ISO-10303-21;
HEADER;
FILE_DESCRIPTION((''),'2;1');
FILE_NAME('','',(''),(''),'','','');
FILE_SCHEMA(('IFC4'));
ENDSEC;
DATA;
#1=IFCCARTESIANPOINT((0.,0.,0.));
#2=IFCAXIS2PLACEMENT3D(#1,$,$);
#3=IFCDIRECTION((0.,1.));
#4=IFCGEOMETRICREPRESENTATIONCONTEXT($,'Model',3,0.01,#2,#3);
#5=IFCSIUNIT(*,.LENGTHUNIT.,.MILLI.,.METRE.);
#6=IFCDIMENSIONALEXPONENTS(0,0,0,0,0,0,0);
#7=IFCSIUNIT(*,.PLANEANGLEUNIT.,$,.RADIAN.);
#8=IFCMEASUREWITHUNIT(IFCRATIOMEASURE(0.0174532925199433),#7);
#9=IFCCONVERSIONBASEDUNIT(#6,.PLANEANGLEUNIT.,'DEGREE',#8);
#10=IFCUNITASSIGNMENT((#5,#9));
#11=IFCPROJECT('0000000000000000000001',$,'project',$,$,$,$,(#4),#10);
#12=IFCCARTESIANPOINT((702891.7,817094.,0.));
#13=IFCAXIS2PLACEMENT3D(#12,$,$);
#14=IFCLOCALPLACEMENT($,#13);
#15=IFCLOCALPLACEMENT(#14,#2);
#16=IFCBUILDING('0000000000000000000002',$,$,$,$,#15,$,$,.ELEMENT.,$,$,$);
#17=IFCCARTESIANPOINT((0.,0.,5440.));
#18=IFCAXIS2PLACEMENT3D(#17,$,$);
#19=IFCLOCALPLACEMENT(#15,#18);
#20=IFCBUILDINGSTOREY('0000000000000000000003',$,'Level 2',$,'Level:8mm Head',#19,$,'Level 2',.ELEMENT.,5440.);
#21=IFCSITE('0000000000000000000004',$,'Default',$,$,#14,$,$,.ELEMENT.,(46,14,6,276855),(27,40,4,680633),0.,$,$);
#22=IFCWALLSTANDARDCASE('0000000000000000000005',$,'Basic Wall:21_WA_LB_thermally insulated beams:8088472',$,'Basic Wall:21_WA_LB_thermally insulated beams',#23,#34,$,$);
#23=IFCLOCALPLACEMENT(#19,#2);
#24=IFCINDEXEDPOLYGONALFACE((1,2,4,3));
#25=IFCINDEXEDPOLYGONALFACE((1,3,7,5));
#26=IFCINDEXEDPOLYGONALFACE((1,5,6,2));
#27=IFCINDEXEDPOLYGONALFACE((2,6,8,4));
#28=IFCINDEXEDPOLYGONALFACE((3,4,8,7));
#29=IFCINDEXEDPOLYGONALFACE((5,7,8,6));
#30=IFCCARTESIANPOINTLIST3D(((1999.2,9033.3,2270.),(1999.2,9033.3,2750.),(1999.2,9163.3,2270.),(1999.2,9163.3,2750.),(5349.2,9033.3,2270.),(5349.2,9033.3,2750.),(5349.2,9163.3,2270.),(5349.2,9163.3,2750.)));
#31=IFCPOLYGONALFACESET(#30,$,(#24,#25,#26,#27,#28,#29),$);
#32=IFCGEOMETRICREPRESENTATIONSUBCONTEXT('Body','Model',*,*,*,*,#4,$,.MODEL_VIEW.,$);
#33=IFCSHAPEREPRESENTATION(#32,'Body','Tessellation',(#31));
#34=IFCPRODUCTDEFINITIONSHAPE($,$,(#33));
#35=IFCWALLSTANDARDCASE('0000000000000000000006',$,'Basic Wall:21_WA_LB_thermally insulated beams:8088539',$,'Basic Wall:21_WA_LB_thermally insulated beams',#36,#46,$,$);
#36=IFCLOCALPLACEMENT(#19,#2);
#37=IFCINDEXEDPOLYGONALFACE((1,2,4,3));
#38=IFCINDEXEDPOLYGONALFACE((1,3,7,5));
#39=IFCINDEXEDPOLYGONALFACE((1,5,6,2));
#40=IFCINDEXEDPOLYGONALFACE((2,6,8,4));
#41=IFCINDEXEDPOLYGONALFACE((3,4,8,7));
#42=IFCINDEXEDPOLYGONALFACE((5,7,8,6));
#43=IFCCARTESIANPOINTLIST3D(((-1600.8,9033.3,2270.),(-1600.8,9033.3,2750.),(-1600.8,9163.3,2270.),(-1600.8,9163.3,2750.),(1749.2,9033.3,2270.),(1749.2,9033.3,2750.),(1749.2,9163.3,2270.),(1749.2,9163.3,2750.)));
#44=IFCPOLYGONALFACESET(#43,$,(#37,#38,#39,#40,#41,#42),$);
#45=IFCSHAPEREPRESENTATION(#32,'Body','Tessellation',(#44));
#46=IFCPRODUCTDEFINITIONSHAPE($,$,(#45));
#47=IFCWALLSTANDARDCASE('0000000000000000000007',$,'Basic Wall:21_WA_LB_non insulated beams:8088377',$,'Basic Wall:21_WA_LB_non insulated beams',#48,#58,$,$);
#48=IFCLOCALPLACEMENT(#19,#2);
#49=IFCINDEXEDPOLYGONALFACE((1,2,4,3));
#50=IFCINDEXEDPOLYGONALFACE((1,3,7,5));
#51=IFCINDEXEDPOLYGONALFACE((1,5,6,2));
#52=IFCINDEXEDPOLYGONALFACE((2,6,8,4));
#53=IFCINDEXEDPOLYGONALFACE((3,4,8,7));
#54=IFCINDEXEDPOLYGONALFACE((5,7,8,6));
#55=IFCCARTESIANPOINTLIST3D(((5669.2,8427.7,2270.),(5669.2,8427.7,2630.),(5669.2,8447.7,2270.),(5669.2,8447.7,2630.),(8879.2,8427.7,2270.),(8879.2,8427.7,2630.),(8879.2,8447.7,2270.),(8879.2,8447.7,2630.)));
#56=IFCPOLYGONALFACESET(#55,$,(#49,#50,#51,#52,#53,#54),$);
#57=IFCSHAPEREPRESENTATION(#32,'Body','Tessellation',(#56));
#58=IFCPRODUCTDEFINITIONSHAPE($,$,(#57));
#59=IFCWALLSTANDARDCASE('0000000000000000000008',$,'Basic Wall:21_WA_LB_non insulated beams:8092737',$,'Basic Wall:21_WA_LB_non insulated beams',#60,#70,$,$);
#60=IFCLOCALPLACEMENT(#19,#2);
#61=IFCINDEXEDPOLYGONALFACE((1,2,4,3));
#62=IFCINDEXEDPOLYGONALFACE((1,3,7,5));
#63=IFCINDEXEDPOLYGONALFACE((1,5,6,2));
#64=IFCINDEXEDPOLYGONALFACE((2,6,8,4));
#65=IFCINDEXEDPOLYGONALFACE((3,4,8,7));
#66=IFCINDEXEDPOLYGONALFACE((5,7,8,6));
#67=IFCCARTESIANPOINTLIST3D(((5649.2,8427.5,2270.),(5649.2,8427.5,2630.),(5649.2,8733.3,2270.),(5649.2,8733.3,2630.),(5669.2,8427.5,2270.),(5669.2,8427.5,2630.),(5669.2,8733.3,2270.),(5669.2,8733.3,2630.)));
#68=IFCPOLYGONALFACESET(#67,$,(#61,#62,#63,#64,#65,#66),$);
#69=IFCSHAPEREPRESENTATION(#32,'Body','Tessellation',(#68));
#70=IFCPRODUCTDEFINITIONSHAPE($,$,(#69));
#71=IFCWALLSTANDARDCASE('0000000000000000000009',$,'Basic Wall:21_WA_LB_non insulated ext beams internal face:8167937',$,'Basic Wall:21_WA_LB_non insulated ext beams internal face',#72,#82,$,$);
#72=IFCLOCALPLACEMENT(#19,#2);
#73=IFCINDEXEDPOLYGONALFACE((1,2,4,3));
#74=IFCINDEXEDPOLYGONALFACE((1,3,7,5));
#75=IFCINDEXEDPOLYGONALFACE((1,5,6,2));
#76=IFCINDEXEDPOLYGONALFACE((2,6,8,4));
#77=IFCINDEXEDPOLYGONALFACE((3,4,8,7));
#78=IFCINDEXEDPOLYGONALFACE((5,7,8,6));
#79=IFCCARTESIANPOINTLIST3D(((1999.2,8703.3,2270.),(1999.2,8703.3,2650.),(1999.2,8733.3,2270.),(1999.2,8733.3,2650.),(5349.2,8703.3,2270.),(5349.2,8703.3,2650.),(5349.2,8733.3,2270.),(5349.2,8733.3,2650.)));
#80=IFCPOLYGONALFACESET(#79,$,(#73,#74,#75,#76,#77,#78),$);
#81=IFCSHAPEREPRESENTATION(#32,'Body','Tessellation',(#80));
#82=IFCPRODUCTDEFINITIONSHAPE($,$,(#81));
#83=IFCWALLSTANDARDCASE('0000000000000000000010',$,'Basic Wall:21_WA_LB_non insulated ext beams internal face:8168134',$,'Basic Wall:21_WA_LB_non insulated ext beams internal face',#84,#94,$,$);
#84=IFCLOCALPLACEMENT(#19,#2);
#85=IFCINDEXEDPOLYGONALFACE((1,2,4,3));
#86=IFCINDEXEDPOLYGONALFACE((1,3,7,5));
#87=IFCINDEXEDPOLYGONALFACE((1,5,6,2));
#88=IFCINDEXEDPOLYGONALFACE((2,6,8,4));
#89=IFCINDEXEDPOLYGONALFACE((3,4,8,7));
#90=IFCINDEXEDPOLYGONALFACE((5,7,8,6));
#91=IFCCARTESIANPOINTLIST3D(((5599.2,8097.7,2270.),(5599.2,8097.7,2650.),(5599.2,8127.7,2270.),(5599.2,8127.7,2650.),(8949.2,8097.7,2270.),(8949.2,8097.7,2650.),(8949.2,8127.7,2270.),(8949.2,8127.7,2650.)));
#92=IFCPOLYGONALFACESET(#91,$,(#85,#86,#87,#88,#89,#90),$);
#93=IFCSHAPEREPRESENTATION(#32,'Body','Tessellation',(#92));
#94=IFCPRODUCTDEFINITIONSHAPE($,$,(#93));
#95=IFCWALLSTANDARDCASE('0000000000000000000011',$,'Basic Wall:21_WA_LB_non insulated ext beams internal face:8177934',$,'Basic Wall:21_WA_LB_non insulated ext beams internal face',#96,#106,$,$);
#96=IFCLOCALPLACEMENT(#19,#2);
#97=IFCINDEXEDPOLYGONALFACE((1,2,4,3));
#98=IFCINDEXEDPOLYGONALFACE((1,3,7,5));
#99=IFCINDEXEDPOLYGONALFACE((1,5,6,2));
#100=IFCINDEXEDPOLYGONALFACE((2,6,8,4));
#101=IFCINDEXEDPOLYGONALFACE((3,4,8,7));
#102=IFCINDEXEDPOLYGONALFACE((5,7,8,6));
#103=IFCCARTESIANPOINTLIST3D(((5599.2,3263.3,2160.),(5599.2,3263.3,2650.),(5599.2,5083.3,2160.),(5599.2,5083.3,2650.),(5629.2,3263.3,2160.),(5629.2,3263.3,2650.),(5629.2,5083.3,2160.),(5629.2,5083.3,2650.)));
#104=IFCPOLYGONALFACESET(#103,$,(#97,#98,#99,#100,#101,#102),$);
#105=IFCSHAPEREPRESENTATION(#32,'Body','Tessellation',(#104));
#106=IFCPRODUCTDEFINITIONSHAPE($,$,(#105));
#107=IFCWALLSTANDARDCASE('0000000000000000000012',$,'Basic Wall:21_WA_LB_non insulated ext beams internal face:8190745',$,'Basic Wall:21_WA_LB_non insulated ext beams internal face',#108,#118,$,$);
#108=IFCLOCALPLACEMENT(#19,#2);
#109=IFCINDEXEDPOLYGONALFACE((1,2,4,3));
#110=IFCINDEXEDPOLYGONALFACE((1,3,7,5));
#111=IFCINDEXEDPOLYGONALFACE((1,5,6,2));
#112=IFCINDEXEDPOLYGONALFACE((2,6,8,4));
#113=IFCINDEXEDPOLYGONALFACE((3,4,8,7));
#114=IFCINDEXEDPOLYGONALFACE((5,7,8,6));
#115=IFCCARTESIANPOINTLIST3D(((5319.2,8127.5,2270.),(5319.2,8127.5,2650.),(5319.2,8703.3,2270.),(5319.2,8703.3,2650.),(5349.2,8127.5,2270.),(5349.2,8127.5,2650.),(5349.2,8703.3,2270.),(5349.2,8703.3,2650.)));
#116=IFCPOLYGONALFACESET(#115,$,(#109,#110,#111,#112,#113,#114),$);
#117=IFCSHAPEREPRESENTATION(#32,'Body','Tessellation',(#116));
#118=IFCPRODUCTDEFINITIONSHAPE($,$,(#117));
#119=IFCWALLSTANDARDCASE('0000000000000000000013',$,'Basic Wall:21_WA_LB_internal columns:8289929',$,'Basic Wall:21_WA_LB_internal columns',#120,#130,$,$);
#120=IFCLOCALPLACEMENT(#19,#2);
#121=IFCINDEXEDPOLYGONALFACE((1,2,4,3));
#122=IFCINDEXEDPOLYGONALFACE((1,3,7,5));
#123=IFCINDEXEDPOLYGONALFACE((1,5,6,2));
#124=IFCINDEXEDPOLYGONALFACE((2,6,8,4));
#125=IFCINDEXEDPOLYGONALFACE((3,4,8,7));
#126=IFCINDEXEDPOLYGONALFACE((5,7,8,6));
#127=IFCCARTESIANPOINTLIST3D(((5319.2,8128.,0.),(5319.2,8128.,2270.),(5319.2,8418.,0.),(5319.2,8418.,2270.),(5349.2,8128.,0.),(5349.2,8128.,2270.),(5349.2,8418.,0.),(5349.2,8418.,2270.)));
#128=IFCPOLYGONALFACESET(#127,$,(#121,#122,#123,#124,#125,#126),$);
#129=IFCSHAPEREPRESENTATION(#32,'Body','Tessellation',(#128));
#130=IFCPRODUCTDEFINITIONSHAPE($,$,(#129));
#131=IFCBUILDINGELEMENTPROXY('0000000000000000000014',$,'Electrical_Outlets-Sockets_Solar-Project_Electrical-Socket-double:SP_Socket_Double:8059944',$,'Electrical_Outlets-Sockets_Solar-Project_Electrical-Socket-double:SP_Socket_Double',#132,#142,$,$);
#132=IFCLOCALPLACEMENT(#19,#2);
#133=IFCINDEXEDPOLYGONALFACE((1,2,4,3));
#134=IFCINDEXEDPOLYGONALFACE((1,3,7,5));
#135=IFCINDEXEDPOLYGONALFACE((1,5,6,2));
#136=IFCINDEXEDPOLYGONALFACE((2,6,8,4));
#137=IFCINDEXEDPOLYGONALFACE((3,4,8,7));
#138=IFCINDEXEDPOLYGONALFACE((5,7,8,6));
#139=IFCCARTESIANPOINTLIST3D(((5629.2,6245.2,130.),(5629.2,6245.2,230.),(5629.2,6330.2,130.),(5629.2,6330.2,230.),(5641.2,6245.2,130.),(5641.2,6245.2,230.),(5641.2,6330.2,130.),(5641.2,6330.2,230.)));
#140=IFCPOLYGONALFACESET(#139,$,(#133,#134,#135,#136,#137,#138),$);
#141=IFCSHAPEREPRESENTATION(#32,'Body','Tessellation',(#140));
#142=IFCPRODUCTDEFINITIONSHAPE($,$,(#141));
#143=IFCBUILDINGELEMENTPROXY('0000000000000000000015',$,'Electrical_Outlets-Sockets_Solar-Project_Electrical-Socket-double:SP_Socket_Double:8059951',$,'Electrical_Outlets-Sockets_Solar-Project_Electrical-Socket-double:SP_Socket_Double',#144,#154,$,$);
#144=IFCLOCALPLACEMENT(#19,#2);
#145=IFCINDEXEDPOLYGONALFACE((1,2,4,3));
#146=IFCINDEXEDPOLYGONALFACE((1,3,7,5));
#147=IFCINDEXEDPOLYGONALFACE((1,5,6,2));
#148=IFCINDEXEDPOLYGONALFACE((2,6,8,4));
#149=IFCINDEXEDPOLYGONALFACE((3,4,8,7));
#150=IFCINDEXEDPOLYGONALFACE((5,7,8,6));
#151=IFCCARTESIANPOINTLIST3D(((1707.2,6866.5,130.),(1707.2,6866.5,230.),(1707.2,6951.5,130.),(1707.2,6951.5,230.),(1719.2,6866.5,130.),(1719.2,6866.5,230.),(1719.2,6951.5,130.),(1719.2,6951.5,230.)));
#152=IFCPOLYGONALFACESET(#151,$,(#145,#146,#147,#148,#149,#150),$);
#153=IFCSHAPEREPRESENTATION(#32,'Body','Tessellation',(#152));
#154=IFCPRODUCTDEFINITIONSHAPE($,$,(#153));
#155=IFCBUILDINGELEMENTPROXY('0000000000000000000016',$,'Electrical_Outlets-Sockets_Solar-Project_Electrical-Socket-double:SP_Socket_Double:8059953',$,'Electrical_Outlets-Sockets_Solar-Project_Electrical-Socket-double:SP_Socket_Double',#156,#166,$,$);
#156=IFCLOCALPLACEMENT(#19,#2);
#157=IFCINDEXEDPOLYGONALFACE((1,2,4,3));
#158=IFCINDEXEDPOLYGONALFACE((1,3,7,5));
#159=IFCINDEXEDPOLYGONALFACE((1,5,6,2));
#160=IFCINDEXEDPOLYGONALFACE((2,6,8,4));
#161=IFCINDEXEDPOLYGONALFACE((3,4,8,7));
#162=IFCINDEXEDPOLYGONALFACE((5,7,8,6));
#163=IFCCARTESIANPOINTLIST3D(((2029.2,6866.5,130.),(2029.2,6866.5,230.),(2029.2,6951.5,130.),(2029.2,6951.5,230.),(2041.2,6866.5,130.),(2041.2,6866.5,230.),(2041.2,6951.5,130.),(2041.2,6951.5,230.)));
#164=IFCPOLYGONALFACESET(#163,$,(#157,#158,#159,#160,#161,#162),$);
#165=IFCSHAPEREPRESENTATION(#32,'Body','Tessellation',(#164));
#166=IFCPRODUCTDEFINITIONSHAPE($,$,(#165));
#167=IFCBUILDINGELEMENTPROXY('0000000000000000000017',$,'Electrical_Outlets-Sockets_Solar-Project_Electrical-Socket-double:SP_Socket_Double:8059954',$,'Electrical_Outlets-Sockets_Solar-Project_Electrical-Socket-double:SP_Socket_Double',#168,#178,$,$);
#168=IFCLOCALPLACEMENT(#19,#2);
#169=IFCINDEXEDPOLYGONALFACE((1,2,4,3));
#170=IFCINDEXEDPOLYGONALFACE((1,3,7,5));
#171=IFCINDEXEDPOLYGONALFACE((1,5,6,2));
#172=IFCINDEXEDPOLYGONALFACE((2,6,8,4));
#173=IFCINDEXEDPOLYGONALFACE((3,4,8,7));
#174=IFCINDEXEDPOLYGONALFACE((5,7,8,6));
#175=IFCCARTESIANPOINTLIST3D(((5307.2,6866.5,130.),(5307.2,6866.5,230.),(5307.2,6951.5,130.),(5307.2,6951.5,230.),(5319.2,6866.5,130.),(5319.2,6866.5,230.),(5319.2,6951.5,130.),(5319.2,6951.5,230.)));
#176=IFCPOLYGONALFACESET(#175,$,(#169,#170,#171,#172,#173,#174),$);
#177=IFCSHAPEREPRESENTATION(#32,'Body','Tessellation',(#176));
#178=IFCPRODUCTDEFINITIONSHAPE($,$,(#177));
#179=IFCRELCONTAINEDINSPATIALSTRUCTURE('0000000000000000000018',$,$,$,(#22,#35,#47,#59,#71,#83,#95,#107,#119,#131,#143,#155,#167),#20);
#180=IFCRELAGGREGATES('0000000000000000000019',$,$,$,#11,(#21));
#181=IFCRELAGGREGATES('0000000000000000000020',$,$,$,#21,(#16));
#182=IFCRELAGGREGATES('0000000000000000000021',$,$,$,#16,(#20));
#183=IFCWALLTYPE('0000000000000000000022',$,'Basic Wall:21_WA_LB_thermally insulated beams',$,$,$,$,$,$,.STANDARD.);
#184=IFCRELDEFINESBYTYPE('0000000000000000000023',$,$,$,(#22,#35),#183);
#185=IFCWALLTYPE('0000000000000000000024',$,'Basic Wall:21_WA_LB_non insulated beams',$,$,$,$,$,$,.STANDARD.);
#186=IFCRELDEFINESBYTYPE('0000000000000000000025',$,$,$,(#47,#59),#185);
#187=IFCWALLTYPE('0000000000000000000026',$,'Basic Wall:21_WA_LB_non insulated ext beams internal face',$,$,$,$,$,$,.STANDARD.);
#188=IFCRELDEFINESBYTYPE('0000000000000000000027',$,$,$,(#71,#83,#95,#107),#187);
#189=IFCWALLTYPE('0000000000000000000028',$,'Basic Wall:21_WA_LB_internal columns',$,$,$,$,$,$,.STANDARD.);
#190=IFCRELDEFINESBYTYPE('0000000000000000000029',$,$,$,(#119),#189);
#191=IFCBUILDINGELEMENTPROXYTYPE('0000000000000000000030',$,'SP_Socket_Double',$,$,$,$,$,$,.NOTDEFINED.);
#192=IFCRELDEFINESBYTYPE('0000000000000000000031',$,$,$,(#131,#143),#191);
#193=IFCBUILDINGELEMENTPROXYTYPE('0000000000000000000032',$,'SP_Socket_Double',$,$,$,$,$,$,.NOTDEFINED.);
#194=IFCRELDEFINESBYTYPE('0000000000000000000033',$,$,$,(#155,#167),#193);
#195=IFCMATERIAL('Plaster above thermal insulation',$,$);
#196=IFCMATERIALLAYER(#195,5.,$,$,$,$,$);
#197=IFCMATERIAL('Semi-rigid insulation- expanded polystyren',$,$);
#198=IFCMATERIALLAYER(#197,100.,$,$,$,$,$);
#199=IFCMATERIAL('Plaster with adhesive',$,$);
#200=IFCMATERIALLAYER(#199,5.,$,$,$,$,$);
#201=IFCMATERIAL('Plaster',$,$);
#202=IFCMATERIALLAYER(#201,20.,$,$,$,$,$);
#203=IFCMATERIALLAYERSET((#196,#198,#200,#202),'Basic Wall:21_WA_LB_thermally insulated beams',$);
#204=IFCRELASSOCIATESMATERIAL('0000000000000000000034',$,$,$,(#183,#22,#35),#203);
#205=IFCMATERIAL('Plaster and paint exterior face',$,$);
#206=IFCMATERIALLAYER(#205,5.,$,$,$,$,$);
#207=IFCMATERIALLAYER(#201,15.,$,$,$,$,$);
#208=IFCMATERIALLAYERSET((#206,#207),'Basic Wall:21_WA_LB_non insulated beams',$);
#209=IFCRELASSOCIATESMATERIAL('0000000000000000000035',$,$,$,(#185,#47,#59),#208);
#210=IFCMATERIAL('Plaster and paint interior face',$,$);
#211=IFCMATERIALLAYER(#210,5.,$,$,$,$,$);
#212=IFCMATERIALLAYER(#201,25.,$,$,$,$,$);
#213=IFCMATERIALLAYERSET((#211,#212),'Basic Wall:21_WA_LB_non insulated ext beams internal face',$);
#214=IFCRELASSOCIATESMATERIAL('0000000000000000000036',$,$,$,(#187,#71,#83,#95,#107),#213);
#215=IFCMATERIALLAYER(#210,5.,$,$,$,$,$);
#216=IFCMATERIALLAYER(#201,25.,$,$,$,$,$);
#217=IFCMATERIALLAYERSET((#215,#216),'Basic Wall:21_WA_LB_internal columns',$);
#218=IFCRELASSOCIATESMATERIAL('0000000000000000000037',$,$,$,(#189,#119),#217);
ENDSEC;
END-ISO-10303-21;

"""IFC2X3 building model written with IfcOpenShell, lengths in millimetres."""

from ifc_helpers import new_model, entity, si_unit, converted_unit, direction, frame, frame_2d, origin, origin_2d_with_axis, place, context, subcontext, project, spatial, rectangle, extrude, source, transform, mapped, material, layer, layer_set, layer_usage, type_object, type_shapes, element, save


model = new_model("IFC2X3")

# Units and contexts
model_context = context("Model", 3, precision=0.01, world=origin(), true_north=direction((0.0, 1.0)))
body_context = subcontext(model_context, "Body", "Model", "MODEL_VIEW")
ifc_project = project(units=[si_unit("LENGTHUNIT", "METRE", prefix="MILLI"), converted_unit("PLANEANGLEUNIT", "DEGREE", entity("IfcRatioMeasure", 0.0174532925199433), si_unit("PLANEANGLEUNIT", "RADIAN"), dimensions=[0, 0, 0, 0, 0, 0, 0])], contexts=[model_context])

# Site, building, storey
site_placement = place(None, frame((702891.7, 817094.0, 0.0)))
site = spatial("IfcSite", under=ifc_project, at=site_placement, Name="Default", CompositionType="ELEMENT", RefLatitude=(46, 14, 6, 276855), RefLongitude=(27, 40, 4, 680633), RefElevation=0.0)
building_placement = place(site_placement, origin())
building = spatial("IfcBuilding", under=site, at=building_placement, CompositionType="ELEMENT")
storey_placement = place(building_placement, frame((0.0, 0.0, 5440.0)))
storey = spatial("IfcBuildingStorey", under=building, at=storey_placement, Name="Level 2", ObjectType="Level:8mm Head", LongName="Level 2", CompositionType="ELEMENT", Elevation=5440.0)

# Shared definitions
ifc_material_1 = material(Name="Plaster above thermal insulation")
ifc_material_2 = material(Name="Semi-rigid insulation- expanded polystyren")
ifc_material_3 = material(Name="Plaster with adhesive")
ifc_material_4 = material(Name="Plaster")
ifc_material_5 = material(Name="Plaster and paint interior face")

# Walls
ifc_material_6 = material(Name="Plaster and paint exterior face")
ifc_layer_1 = layer(ifc_material_1, 5.0)
ifc_layer_2 = layer(ifc_material_2, 100.0)
ifc_layer_3 = layer(ifc_material_3, 5.0)
ifc_layer_4 = layer(ifc_material_4, 20.0)
ifc_layer_set_1 = layer_set([ifc_layer_1, ifc_layer_2, ifc_layer_3, ifc_layer_4], Name="Basic Wall:21_WA_LB_thermally insulated beams")
ifc_layer_usage_1 = layer_usage(ifc_layer_set_1, "AXIS2", "POSITIVE", -65.0)
wall_type_1 = type_object("IfcWallType", Name="Basic Wall:21_WA_LB_thermally insulated beams", PredefinedType="STANDARD", material=ifc_layer_set_1)
wall_1_placement = place(storey_placement, frame((5349.2, 9098.3, 2270.0), z_axis=(0.0, 0.0, 1.0), x_axis=(-1.0, 0.0, 0.0)))
element("IfcWallStandardCase", 1, at=wall_1_placement, inside=storey, type_object=wall_type_1, material=ifc_layer_usage_1, Name="Basic Wall:21_WA_LB_thermally insulated beams:8088472", ObjectType="Basic Wall:21_WA_LB_thermally insulated beams", context=body_context, shape_type="SweptSolid", body=[
    extrude(rectangle(XDim=3350.0, YDim=130.0, at=frame_2d((1675.0, 0.0), x_axis=(-1.0, 0.0))), origin(), (0.0, 0.0, 1.0), 480.0),
])
ifc_layer_usage_2 = layer_usage(ifc_layer_set_1, "AXIS2", "POSITIVE", -65.0)
wall_2_placement = place(storey_placement, frame((1749.2, 9098.3, 2270.0), z_axis=(0.0, 0.0, 1.0), x_axis=(-1.0, 0.0, 0.0)))
element("IfcWallStandardCase", 2, at=wall_2_placement, inside=storey, type_object=wall_type_1, material=ifc_layer_usage_2, Name="Basic Wall:21_WA_LB_thermally insulated beams:8088539", ObjectType="Basic Wall:21_WA_LB_thermally insulated beams", context=body_context, shape_type="SweptSolid", body=[
    extrude(rectangle(XDim=3350.0, YDim=130.0, at=frame_2d((1675.0, 0.0), x_axis=(-1.0, 0.0))), origin(), (0.0, 0.0, 1.0), 480.0),
])
ifc_layer_5 = layer(ifc_material_6, 5.0)
ifc_layer_6 = layer(ifc_material_4, 15.0)
ifc_layer_set_2 = layer_set([ifc_layer_5, ifc_layer_6], Name="Basic Wall:21_WA_LB_non insulated beams")
ifc_layer_usage_3 = layer_usage(ifc_layer_set_2, "AXIS2", "NEGATIVE", 10.0)
wall_type_2 = type_object("IfcWallType", Name="Basic Wall:21_WA_LB_non insulated beams", PredefinedType="STANDARD", material=ifc_layer_set_2)
wall_3_placement = place(storey_placement, frame((5669.2, 8437.7, 2270.0)))
element("IfcWallStandardCase", 3, at=wall_3_placement, inside=storey, type_object=wall_type_2, material=ifc_layer_usage_3, Name="Basic Wall:21_WA_LB_non insulated beams:8088377", ObjectType="Basic Wall:21_WA_LB_non insulated beams", context=body_context, shape_type="SweptSolid", body=[
    extrude(rectangle(XDim=3210.0, YDim=20.0, at=frame_2d((1605.0, 0.0), x_axis=(-1.0, 0.0))), origin(), (0.0, 0.0, 1.0), 360.0),
])
ifc_layer_usage_4 = layer_usage(ifc_layer_set_2, "AXIS2", "NEGATIVE", 10.0)
wall_4_placement = place(storey_placement, frame((5659.2, 8733.3, 2270.0), z_axis=(0.0, 0.0, 1.0), x_axis=(0.0, -1.0, 0.0)))
element("IfcWallStandardCase", 4, at=wall_4_placement, inside=storey, type_object=wall_type_2, material=ifc_layer_usage_4, Name="Basic Wall:21_WA_LB_non insulated beams:8092737", ObjectType="Basic Wall:21_WA_LB_non insulated beams", context=body_context, shape_type="SweptSolid", body=[
    extrude(rectangle(XDim=305.8, YDim=20.0, at=frame_2d((152.9, 0.0), x_axis=(-1.0, 0.0))), origin(), (0.0, 0.0, 1.0), 360.0),
])
ifc_layer_7 = layer(ifc_material_5, 5.0)
ifc_layer_8 = layer(ifc_material_4, 25.0)
ifc_layer_set_3 = layer_set([ifc_layer_7, ifc_layer_8], Name="Basic Wall:21_WA_LB_non insulated ext beams internal face")
ifc_layer_usage_5 = layer_usage(ifc_layer_set_3, "AXIS2", "POSITIVE", -15.0)
wall_type_3 = type_object("IfcWallType", Name="Basic Wall:21_WA_LB_non insulated ext beams internal face", PredefinedType="STANDARD", material=ifc_layer_set_3)
wall_5_placement = place(storey_placement, frame((1999.2, 8718.3, 2270.0)))
element("IfcWallStandardCase", 5, at=wall_5_placement, inside=storey, type_object=wall_type_3, material=ifc_layer_usage_5, Name="Basic Wall:21_WA_LB_non insulated ext beams internal face:8167937", ObjectType="Basic Wall:21_WA_LB_non insulated ext beams internal face", context=body_context, shape_type="SweptSolid", body=[
    extrude(rectangle(XDim=3350.0, YDim=30.0, at=frame_2d((1675.0, 0.0), x_axis=(-1.0, 0.0))), origin(), (0.0, 0.0, 1.0), 380.0),
])
ifc_layer_usage_6 = layer_usage(ifc_layer_set_3, "AXIS2", "POSITIVE", -15.0)
wall_6_placement = place(storey_placement, frame((5599.2, 8112.7, 2270.0)))
element("IfcWallStandardCase", 6, at=wall_6_placement, inside=storey, type_object=wall_type_3, material=ifc_layer_usage_6, Name="Basic Wall:21_WA_LB_non insulated ext beams internal face:8168134", ObjectType="Basic Wall:21_WA_LB_non insulated ext beams internal face", context=body_context, shape_type="SweptSolid", body=[
    extrude(rectangle(XDim=3350.0, YDim=30.0, at=frame_2d((1675.0, 0.0), x_axis=(-1.0, 0.0))), origin(), (0.0, 0.0, 1.0), 380.0),
])
ifc_layer_usage_7 = layer_usage(ifc_layer_set_3, "AXIS2", "NEGATIVE", 15.0)
wall_7_placement = place(storey_placement, frame((5614.2, 5083.3, 2160.0), z_axis=(0.0, 0.0, 1.0), x_axis=(0.0, -1.0, 0.0)))
element("IfcWallStandardCase", 7, at=wall_7_placement, inside=storey, type_object=wall_type_3, material=ifc_layer_usage_7, Name="Basic Wall:21_WA_LB_non insulated ext beams internal face:8177934", ObjectType="Basic Wall:21_WA_LB_non insulated ext beams internal face", context=body_context, shape_type="SweptSolid", body=[
    extrude(rectangle(XDim=1820.0, YDim=30.0, at=frame_2d((910.0, 0.0), x_axis=(-1.0, 0.0))), origin(), (0.0, 0.0, 1.0), 490.0),
])
ifc_layer_usage_8 = layer_usage(ifc_layer_set_3, "AXIS2", "NEGATIVE", 15.0)
wall_8_placement = place(storey_placement, frame((5334.2, 8127.5, 2270.0), z_axis=(0.0, 0.0, 1.0), x_axis=(0.0, 1.0, 0.0)))
element("IfcWallStandardCase", 8, at=wall_8_placement, inside=storey, type_object=wall_type_3, material=ifc_layer_usage_8, Name="Basic Wall:21_WA_LB_non insulated ext beams internal face:8190745", ObjectType="Basic Wall:21_WA_LB_non insulated ext beams internal face", context=body_context, shape_type="SweptSolid", body=[
    extrude(rectangle(XDim=575.8, YDim=30.0, at=frame_2d((287.9, 0.0), x_axis=(-1.0, 0.0))), origin(), (0.0, 0.0, 1.0), 380.0),
])
ifc_layer_9 = layer(ifc_material_5, 5.0)
ifc_layer_10 = layer(ifc_material_4, 25.0)
ifc_layer_set_4 = layer_set([ifc_layer_9, ifc_layer_10], Name="Basic Wall:21_WA_LB_internal columns")
ifc_layer_usage_9 = layer_usage(ifc_layer_set_4, "AXIS2", "POSITIVE", -15.0)
wall_type_4 = type_object("IfcWallType", Name="Basic Wall:21_WA_LB_internal columns", PredefinedType="STANDARD", material=ifc_layer_set_4)
wall_9_placement = place(storey_placement, frame((5334.2, 8418.0, 0.0), z_axis=(0.0, 0.0, 1.0), x_axis=(0.0, -1.0, 0.0)))
element("IfcWallStandardCase", 9, at=wall_9_placement, inside=storey, type_object=wall_type_4, material=ifc_layer_usage_9, Name="Basic Wall:21_WA_LB_internal columns:8289929", ObjectType="Basic Wall:21_WA_LB_internal columns", context=body_context, shape_type="SweptSolid", body=[
    extrude(rectangle(XDim=290.0, YDim=30.0, at=frame_2d((145.0, 0.0), x_axis=(-1.0, 0.0))), origin(), (0.0, 0.0, 1.0), 2270.0),
])

# Building element proxies
building_element_proxy_type_1 = type_object("IfcBuildingElementProxyType", Name="SP_Socket_Double", PredefinedType="NOTDEFINED")
shared_shape_1 = source(origin(), body_context, "Body", "SweptSolid", [
    extrude(rectangle(XDim=85.0, YDim=12.0, at=origin_2d_with_axis()), frame((0.0, 6.0, -100.0), z_axis=(0.0, 0.0, 1.0), x_axis=(-1.0, 0.0, 0.0)), (0.0, 0.0, 1.0), 100.0),
])
type_shapes(building_element_proxy_type_1, [shared_shape_1])
for number, where, z_axis, x_axis, name in (
    (10, (5629.2, 6287.7, 230.0), (0.0, 0.0, 1.0), (0.0, -1.0, 0.0), "Electrical_Outlets-Sockets_Solar-Project_Electrical-Socket-double:SP_Socket_Double:8059944"),
    (11, (1719.2, 6909.0, 230.0), (0.0, 0.0, 1.0), (0.0, 1.0, 0.0), "Electrical_Outlets-Sockets_Solar-Project_Electrical-Socket-double:SP_Socket_Double:8059951"),
):
    element("IfcBuildingElementProxy", number, at=place(storey_placement, frame(where, z_axis=z_axis, x_axis=x_axis)), inside=storey, type_object=building_element_proxy_type_1, Name=name, ObjectType="Electrical_Outlets-Sockets_Solar-Project_Electrical-Socket-double:SP_Socket_Double", context=body_context, shape_type="MappedRepresentation", body=[
        mapped(shared_shape_1, transform((0.0, 0.0, 0.0), scale=1.0)),
    ])
building_element_proxy_type_2 = type_object("IfcBuildingElementProxyType", Name="SP_Socket_Double", PredefinedType="NOTDEFINED")
shared_shape_2 = source(origin(), body_context, "Body", "SweptSolid", [
    extrude(rectangle(XDim=12.0, YDim=85.0, at=origin_2d_with_axis()), frame((0.0, -6.0, -100.0), z_axis=(0.0, 0.0, 1.0), x_axis=(0.0, 1.0, 0.0)), (0.0, 0.0, 1.0), 100.0),
])
type_shapes(building_element_proxy_type_2, [shared_shape_2])
for number, where, z_axis, x_axis, name in (
    (12, (2029.2, 6909.0, 230.0), (0.0, 0.0, 1.0), (0.0, 1.0, 0.0), "Electrical_Outlets-Sockets_Solar-Project_Electrical-Socket-double:SP_Socket_Double:8059953"),
    (13, (5319.2, 6909.0, 230.0), (0.0, 0.0, 1.0), (0.0, -1.0, 0.0), "Electrical_Outlets-Sockets_Solar-Project_Electrical-Socket-double:SP_Socket_Double:8059954"),
):
    element("IfcBuildingElementProxy", number, at=place(storey_placement, frame(where, z_axis=z_axis, x_axis=x_axis)), inside=storey, type_object=building_element_proxy_type_2, Name=name, ObjectType="Electrical_Outlets-Sockets_Solar-Project_Electrical-Socket-double:SP_Socket_Double", context=body_context, shape_type="MappedRepresentation", body=[
        mapped(shared_shape_2, transform((0.0, 0.0, 0.0), scale=1.0)),
    ])

save(model, "model.ifc")
